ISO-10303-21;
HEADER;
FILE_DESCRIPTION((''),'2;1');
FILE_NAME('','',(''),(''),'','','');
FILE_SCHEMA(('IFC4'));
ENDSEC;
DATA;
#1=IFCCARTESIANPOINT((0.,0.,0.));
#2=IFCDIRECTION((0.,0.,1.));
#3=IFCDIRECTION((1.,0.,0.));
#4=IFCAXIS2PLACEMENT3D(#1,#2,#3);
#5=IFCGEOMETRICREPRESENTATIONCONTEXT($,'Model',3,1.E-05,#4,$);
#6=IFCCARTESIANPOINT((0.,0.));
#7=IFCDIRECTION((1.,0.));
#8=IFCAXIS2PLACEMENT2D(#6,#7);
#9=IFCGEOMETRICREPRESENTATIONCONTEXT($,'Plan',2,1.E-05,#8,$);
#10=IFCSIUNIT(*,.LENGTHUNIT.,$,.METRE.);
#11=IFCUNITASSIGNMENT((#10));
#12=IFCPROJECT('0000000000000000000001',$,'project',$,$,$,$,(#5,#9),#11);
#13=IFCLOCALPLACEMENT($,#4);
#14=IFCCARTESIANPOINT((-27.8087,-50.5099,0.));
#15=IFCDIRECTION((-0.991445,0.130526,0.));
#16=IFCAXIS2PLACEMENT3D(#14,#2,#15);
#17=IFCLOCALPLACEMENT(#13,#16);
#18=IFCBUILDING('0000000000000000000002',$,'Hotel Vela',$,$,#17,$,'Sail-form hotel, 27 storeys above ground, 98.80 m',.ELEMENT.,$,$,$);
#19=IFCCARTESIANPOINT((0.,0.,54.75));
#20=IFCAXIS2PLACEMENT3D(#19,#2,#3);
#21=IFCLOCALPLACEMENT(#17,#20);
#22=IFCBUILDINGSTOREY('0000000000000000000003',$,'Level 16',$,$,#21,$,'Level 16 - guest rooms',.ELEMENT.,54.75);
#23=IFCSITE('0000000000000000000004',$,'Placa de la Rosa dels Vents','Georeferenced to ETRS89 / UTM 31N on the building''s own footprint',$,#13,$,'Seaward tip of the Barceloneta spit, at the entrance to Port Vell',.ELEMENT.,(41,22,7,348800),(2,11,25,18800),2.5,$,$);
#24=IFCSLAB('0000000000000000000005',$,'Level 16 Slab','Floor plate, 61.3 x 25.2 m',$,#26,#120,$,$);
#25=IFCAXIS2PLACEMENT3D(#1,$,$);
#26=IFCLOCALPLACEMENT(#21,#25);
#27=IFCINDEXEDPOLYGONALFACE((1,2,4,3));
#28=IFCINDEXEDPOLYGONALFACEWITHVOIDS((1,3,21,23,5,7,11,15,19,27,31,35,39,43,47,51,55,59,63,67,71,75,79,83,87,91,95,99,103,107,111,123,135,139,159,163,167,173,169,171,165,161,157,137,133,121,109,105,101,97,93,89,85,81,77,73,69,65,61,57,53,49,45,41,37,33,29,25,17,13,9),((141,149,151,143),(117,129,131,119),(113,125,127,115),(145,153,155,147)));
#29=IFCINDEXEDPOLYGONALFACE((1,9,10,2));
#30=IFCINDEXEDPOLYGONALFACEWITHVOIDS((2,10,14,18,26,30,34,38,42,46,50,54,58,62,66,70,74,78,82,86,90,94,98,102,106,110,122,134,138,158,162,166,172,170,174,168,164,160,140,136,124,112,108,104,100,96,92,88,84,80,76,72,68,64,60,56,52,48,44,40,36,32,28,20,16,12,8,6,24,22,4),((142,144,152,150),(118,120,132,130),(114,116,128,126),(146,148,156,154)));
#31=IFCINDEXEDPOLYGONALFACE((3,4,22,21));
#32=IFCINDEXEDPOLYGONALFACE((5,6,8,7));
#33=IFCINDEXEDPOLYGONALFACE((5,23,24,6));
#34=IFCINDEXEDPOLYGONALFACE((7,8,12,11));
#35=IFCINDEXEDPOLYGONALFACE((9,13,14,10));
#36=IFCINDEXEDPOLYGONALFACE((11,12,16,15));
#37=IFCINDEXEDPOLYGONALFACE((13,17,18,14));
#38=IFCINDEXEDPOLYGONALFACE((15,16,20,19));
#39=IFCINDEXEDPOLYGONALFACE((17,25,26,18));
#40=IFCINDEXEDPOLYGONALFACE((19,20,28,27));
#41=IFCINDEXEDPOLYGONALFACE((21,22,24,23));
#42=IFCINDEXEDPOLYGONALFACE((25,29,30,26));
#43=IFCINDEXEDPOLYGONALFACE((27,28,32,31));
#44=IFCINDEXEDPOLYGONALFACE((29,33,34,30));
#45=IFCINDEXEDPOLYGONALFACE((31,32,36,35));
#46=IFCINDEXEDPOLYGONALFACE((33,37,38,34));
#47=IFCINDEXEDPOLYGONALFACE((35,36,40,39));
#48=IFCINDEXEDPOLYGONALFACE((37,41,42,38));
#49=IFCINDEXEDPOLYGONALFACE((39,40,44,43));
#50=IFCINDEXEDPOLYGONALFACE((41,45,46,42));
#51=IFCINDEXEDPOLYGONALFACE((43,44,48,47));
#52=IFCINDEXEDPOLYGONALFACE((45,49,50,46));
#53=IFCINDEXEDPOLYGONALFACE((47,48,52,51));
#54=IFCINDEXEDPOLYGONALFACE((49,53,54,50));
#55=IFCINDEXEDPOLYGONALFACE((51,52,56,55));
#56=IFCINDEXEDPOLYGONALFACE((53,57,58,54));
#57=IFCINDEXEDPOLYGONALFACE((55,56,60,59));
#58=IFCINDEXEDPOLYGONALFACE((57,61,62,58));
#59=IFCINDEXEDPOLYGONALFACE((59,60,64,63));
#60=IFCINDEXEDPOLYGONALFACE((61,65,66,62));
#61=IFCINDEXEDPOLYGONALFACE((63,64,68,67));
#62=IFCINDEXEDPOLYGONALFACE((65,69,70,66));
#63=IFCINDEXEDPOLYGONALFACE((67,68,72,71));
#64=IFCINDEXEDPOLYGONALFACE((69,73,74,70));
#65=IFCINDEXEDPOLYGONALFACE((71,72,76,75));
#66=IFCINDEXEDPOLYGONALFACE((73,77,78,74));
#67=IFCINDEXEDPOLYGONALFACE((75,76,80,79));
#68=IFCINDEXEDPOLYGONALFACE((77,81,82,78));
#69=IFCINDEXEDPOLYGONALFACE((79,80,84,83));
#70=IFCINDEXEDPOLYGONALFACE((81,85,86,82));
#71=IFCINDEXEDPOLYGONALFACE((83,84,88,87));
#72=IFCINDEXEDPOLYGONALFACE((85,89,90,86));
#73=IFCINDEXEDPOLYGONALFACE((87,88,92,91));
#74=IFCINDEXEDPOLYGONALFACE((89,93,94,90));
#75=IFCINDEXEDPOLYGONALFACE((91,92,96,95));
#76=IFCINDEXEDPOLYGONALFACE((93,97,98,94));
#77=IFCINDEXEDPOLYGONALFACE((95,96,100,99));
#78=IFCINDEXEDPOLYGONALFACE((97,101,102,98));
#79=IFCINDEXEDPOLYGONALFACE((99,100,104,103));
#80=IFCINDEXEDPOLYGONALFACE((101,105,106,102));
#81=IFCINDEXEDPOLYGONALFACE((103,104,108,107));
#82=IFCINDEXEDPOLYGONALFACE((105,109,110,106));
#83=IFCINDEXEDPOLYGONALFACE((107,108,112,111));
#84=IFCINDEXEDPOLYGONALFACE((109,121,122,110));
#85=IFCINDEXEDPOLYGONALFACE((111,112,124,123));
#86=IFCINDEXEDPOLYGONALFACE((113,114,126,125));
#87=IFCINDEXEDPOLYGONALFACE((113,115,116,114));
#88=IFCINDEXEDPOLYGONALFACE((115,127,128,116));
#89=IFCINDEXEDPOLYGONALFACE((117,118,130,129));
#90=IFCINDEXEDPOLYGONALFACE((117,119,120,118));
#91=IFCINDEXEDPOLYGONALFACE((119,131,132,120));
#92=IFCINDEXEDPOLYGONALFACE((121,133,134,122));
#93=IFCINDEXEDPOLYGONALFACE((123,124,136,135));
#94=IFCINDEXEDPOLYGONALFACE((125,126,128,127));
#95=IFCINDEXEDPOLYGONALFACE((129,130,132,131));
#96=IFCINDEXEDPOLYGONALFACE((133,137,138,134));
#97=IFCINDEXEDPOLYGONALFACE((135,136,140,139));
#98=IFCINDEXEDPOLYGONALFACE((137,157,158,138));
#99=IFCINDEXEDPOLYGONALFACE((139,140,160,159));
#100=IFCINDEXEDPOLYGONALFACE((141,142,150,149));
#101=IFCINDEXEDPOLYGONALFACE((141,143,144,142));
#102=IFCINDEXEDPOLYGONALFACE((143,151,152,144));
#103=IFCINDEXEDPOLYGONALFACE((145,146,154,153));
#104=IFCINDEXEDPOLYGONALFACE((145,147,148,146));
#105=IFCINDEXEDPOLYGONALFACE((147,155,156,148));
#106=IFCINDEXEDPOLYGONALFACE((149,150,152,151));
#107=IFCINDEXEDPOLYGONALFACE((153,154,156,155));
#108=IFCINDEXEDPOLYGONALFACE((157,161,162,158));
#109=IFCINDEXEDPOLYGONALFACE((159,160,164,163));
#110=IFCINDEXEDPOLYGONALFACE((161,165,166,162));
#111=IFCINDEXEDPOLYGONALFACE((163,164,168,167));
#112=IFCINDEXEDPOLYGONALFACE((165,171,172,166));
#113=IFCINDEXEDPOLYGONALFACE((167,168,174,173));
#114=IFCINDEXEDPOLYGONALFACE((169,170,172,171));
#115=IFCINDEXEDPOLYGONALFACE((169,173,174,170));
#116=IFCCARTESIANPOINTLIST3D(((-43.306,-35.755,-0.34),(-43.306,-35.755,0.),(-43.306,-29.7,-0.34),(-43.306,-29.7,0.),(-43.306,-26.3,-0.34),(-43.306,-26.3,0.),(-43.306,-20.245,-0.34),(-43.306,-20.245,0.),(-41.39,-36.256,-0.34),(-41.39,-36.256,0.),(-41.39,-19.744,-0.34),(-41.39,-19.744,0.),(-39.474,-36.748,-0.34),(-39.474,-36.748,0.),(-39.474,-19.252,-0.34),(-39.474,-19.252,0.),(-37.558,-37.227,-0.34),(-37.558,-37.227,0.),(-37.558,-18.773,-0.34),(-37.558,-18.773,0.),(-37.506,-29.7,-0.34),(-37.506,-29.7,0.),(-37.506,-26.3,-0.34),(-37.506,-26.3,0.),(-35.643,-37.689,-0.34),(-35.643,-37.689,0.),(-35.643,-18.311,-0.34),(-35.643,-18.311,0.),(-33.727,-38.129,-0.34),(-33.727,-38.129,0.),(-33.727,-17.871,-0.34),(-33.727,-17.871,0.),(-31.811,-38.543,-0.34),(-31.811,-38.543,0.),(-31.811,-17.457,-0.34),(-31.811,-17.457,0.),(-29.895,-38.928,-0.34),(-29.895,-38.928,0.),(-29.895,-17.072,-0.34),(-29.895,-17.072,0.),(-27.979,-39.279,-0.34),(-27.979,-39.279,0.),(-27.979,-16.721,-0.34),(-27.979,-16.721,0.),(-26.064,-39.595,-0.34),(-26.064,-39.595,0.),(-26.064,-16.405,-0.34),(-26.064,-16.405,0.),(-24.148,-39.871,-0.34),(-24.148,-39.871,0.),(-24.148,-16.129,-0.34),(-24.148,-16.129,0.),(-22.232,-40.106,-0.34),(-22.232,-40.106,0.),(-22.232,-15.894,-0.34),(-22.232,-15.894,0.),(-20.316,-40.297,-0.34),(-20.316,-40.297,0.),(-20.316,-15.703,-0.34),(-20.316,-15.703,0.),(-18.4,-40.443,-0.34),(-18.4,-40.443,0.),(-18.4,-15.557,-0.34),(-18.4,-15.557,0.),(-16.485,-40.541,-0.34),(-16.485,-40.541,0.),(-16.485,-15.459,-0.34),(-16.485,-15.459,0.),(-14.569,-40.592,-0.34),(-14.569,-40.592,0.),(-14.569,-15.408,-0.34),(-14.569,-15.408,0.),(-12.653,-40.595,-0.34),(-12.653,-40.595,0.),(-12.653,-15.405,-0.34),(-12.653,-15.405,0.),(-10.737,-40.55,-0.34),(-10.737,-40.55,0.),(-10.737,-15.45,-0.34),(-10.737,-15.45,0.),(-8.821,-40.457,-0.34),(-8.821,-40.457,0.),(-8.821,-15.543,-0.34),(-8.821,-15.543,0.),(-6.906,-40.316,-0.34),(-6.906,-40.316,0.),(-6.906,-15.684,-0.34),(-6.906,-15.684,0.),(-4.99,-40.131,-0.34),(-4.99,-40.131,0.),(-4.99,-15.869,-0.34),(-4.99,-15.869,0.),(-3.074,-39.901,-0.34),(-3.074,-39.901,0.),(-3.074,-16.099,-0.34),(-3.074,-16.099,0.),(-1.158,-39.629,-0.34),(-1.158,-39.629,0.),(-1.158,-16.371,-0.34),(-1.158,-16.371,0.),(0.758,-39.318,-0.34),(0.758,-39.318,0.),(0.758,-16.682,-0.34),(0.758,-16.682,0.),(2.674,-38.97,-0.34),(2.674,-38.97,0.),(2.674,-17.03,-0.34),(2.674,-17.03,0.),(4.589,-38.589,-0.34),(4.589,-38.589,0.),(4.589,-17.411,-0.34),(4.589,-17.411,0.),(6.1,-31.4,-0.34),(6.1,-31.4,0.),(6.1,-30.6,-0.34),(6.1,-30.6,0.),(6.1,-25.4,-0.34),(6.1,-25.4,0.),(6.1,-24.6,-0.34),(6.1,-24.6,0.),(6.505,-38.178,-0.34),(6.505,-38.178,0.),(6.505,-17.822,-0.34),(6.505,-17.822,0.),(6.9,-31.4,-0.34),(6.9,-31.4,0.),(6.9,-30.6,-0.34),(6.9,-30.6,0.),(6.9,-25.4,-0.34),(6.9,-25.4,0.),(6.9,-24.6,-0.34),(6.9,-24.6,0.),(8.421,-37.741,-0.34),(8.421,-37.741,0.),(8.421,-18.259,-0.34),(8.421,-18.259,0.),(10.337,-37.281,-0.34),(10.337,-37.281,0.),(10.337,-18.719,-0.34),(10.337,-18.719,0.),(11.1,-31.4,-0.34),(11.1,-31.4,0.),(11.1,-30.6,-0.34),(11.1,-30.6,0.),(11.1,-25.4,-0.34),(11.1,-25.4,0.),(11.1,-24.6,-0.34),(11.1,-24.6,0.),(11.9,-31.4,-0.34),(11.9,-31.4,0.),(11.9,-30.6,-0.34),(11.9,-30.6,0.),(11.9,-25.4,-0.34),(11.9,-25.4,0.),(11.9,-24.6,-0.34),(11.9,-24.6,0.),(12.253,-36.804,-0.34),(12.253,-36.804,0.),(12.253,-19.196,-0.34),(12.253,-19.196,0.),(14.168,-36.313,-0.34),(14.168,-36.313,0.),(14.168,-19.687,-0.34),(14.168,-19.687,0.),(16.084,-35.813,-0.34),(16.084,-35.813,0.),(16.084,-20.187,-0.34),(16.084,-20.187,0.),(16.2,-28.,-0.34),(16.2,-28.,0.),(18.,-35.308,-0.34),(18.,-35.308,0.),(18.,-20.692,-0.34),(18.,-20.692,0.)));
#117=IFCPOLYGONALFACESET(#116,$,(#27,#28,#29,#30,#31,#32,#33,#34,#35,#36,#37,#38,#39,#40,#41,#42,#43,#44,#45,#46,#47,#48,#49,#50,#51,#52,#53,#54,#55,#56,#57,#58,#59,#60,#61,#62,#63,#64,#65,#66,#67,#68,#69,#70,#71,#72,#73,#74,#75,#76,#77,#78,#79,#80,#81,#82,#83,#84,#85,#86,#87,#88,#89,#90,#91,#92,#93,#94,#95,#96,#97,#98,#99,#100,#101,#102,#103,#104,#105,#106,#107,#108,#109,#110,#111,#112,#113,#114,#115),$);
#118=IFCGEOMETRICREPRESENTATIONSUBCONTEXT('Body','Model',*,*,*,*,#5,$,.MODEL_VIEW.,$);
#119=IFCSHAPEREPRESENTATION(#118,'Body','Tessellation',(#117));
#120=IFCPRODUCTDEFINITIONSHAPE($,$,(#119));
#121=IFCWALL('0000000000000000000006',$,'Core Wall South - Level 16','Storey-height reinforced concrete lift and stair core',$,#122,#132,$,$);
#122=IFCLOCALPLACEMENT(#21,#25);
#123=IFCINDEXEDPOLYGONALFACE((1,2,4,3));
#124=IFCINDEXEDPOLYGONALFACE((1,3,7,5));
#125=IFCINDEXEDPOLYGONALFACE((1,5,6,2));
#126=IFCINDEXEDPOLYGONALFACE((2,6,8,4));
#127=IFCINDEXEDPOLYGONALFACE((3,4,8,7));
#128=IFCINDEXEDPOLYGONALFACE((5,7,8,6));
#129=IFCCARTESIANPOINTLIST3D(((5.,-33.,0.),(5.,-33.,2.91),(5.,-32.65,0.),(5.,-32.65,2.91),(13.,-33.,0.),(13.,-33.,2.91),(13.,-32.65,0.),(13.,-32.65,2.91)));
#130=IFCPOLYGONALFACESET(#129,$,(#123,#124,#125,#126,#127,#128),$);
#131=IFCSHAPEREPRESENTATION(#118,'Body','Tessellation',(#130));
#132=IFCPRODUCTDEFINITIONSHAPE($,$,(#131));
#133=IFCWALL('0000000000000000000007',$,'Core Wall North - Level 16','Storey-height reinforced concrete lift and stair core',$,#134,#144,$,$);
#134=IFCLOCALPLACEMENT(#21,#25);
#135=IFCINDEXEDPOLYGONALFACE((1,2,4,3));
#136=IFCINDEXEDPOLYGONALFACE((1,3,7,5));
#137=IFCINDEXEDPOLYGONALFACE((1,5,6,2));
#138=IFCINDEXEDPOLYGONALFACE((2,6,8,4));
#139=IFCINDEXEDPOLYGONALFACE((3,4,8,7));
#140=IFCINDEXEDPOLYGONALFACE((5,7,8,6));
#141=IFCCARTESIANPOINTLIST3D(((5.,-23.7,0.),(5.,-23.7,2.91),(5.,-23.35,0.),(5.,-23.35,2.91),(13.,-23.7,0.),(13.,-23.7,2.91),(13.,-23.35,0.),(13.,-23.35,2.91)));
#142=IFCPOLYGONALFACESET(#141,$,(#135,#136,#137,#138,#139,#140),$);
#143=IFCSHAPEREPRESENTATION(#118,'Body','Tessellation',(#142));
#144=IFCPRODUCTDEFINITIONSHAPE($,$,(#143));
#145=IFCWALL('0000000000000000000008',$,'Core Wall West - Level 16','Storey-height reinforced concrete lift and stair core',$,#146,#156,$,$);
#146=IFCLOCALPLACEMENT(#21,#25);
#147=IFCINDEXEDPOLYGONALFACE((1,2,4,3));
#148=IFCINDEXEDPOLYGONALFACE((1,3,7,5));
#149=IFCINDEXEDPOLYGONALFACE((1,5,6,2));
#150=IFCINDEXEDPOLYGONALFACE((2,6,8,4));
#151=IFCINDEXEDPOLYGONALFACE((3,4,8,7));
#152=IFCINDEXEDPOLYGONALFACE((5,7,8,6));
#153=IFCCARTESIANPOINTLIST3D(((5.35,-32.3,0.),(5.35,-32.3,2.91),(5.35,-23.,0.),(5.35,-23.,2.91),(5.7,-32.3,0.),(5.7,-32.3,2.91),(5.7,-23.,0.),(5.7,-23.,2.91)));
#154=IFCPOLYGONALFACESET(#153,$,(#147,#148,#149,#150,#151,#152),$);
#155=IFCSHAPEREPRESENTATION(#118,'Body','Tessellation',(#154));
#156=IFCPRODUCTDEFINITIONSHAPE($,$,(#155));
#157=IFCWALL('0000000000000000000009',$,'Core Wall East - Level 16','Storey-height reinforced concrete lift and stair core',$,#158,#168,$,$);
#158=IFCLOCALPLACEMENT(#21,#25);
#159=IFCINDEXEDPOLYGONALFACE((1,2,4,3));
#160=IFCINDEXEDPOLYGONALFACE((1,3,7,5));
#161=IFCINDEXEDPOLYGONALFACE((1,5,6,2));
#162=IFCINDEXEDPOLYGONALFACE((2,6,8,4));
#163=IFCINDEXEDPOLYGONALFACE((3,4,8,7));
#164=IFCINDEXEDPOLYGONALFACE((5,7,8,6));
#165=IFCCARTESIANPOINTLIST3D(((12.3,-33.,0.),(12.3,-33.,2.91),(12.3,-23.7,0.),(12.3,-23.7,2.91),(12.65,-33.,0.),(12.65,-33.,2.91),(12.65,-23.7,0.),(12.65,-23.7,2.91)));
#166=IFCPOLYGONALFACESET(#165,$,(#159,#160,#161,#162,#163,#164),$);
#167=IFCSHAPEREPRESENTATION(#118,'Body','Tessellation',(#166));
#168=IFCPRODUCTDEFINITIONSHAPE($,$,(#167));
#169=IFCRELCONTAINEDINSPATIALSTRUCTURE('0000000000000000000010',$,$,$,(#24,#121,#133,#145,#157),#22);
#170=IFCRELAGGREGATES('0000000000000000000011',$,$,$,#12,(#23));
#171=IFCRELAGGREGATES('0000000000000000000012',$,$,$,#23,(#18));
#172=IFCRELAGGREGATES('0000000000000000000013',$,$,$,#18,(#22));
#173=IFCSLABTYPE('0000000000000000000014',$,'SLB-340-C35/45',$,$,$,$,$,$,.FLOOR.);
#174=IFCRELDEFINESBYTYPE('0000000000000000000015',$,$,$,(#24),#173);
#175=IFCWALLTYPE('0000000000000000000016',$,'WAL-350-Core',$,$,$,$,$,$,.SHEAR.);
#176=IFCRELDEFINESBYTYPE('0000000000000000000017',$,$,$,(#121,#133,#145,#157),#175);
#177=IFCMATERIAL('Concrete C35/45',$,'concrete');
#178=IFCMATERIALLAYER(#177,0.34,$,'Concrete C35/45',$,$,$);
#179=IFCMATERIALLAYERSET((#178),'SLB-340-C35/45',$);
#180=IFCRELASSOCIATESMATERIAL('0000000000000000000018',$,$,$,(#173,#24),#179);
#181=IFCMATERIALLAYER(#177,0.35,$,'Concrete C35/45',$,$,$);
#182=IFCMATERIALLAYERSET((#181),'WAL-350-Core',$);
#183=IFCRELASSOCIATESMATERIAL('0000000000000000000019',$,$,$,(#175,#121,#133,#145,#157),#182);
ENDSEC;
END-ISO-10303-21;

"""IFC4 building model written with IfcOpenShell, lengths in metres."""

from ifc_helpers import new_model, si_unit, frame, origin_with_axes, origin_2d_with_axis, place, context, subcontext, project, spatial, line, indexed_curve, outline, extrude, material, layer, layer_set, layer_usage, type_object, element, save


model = new_model("IFC4")

# Units and contexts
model_context = context("Model", 3, precision=1e-05, world=origin_with_axes())
plan_context = context("Plan", 2, precision=1e-05, world=origin_2d_with_axis())
body_context = subcontext(model_context, "Body", "Model", "MODEL_VIEW")
ifc_project = project(units=[si_unit("LENGTHUNIT", "METRE")], contexts=[model_context, plan_context])

# Site, building, storey
site_placement = place(None, origin_with_axes())
site = spatial("IfcSite", under=ifc_project, at=site_placement, Name="Placa de la Rosa dels Vents", Description="Georeferenced to ETRS89 / UTM 31N on the building's own footprint", LongName="Seaward tip of the Barceloneta spit, at the entrance to Port Vell", CompositionType="ELEMENT", RefLatitude=(41, 22, 7, 348800), RefLongitude=(2, 11, 25, 18800), RefElevation=2.5)
building_placement = place(site_placement, frame((-27.8087, -50.5099, 0.0), z_axis=(0.0, 0.0, 1.0), x_axis=(-0.991445, 0.130526, 0.0)))
building = spatial("IfcBuilding", under=site, at=building_placement, Name="Hotel Vela", LongName="Sail-form hotel, 27 storeys above ground, 98.80 m", CompositionType="ELEMENT")
storey_placement = place(building_placement, frame((0.0, 0.0, 54.75), z_axis=(0.0, 0.0, 1.0), x_axis=(1.0, 0.0, 0.0)))
storey = spatial("IfcBuildingStorey", under=building, at=storey_placement, Name="Level 16", LongName="Level 16 - guest rooms", CompositionType="ELEMENT", Elevation=54.75)

# Shared definitions
ifc_material = material(Name="Concrete C35/45", Category="concrete")

# Slab, openings
ifc_layer_1 = layer(ifc_material, 0.34, Name="Concrete C35/45")
ifc_layer_set_1 = layer_set([ifc_layer_1], Name="SLB-340-C35/45")
ifc_layer_usage_1 = layer_usage(ifc_layer_set_1, "AXIS3", "POSITIVE", 0.0)
slab_type = type_object("IfcSlabType", Name="SLB-340-C35/45", PredefinedType="FLOOR", material=ifc_layer_set_1)
slab_placement = place(storey_placement, frame((0.0, 0.0, -0.34), z_axis=(0.0, 0.0, 1.0), x_axis=(1.0, 0.0, 0.0)))
slab = element("IfcSlab", 1, at=slab_placement, inside=storey, type_object=slab_type, material=ifc_layer_usage_1, Name="Level 16 Slab", Description="Floor plate, 61.3 x 25.2 m", context=body_context, shape_type="SweptSolid", body=[
    extrude(outline(indexed_curve([(-43.306, -35.755), (-41.39, -36.256), (-39.474, -36.748), (-37.558, -37.227), (-35.643, -37.689), (-33.727, -38.129), (-31.811, -38.543), (-29.895, -38.928), (-27.979, -39.279), (-26.064, -39.595), (-24.148, -39.871), (-22.232, -40.106), (-20.316, -40.297), (-18.4, -40.443), (-16.485, -40.541), (-14.569, -40.592), (-12.653, -40.595), (-10.737, -40.55), (-8.821, -40.457), (-6.906, -40.316), (-4.99, -40.131), (-3.074, -39.901), (-1.158, -39.629), (0.758, -39.318), (2.674, -38.97), (4.589, -38.589), (6.505, -38.178), (8.421, -37.741), (10.337, -37.281), (12.253, -36.804), (14.168, -36.313), (16.084, -35.813), (18.0, -35.308), (16.2, -28.0), (18.0, -20.692), (16.084, -20.187), (14.168, -19.687), (12.253, -19.196), (10.337, -18.719), (8.421, -18.259), (6.505, -17.822), (4.589, -17.411), (2.674, -17.03), (0.758, -16.682), (-1.158, -16.371), (-3.074, -16.099), (-4.99, -15.869), (-6.906, -15.684), (-8.821, -15.543), (-10.737, -15.45), (-12.653, -15.405), (-14.569, -15.408), (-16.485, -15.459), (-18.4, -15.557), (-20.316, -15.703), (-22.232, -15.894), (-24.148, -16.129), (-26.064, -16.405), (-27.979, -16.721), (-29.895, -17.072), (-31.811, -17.457), (-33.727, -17.871), (-35.643, -18.311), (-37.558, -18.773), (-39.474, -19.252), (-41.39, -19.744), (-43.306, -20.245), (-43.306, -26.3), (-37.506, -26.3), (-37.506, -29.7), (-43.306, -29.7)], segments=[line(1, 2, 3, 4, 5, 6, 7, 8, 9, 10, 11, 12, 13, 14, 15, 16, 17, 18, 19, 20, 21, 22, 23, 24, 25, 26, 27, 28, 29, 30, 31, 32, 33, 34, 35, 36, 37, 38, 39, 40, 41, 42, 43, 44, 45, 46, 47, 48, 49, 50, 51, 52, 53, 54, 55, 56, 57, 58, 59, 60, 61, 62, 63, 64, 65, 66, 67, 68, 69, 70, 71, 1)])), origin_with_axes(), (0.0, 0.0, 1.0), 0.34),
])
opening_1_placement = place(slab_placement, frame((6.1, -31.4, -0.05), z_axis=(0.0, 0.0, 1.0), x_axis=(1.0, 0.0, 0.0)))
element("IfcOpeningElement", 2, at=opening_1_placement, cuts=slab, PredefinedType="OPENING", context=body_context, shape_type="SweptSolid", body=[
    extrude(outline(indexed_curve([(0.0, 0.0), (0.8, 0.0), (0.8, 0.8), (0.0, 0.8)], segments=[line(1, 2, 3, 4, 1)])), origin_with_axes(), (0.0, 0.0, 1.0), 0.44),
])
opening_2_placement = place(slab_placement, frame((6.1, -25.4, -0.05), z_axis=(0.0, 0.0, 1.0), x_axis=(1.0, 0.0, 0.0)))
element("IfcOpeningElement", 3, at=opening_2_placement, cuts=slab, PredefinedType="OPENING", context=body_context, shape_type="SweptSolid", body=[
    extrude(outline(indexed_curve([(0.0, 0.0), (0.8, 0.0), (0.8, 0.8), (0.0, 0.8)], segments=[line(1, 2, 3, 4, 1)])), origin_with_axes(), (0.0, 0.0, 1.0), 0.44),
])
opening_3_placement = place(slab_placement, frame((11.1, -31.4, -0.05), z_axis=(0.0, 0.0, 1.0), x_axis=(1.0, 0.0, 0.0)))
element("IfcOpeningElement", 4, at=opening_3_placement, cuts=slab, PredefinedType="OPENING", context=body_context, shape_type="SweptSolid", body=[
    extrude(outline(indexed_curve([(0.0, 0.0), (0.8, 0.0), (0.8, 0.8), (0.0, 0.8)], segments=[line(1, 2, 3, 4, 1)])), origin_with_axes(), (0.0, 0.0, 1.0), 0.44),
])
opening_4_placement = place(slab_placement, frame((11.1, -25.4, -0.05), z_axis=(0.0, 0.0, 1.0), x_axis=(1.0, 0.0, 0.0)))
element("IfcOpeningElement", 5, at=opening_4_placement, cuts=slab, PredefinedType="OPENING", context=body_context, shape_type="SweptSolid", body=[
    extrude(outline(indexed_curve([(0.0, 0.0), (0.8, 0.0), (0.8, 0.8), (0.0, 0.8)], segments=[line(1, 2, 3, 4, 1)])), origin_with_axes(), (0.0, 0.0, 1.0), 0.44),
])

# Walls
ifc_layer_2 = layer(ifc_material, 0.35, Name="Concrete C35/45")
ifc_layer_set_2 = layer_set([ifc_layer_2], Name="WAL-350-Core")
ifc_layer_usage_2 = layer_usage(ifc_layer_set_2, "AXIS2", "POSITIVE", 0.0)
wall_type = type_object("IfcWallType", Name="WAL-350-Core", PredefinedType="SHEAR", material=ifc_layer_set_2)
wall_1_placement = place(storey_placement, frame((5.0, -33.0, 0.0), z_axis=(0.0, 0.0, 1.0), x_axis=(1.0, 0.0, 0.0)))
element("IfcWall", 6, at=wall_1_placement, inside=storey, type_object=wall_type, material=ifc_layer_usage_2, Name="Core Wall South - Level 16", Description="Storey-height reinforced concrete lift and stair core", context=body_context, shape_type="SweptSolid", body=[
    extrude(outline(indexed_curve([(0.0, 0.0), (8.0, 0.0), (8.0, 0.35), (0.0, 0.35)], segments=[line(1, 2, 3, 4, 1)])), origin_with_axes(), (0.0, 0.0, 1.0), 2.91),
])
ifc_layer_usage_3 = layer_usage(ifc_layer_set_2, "AXIS2", "POSITIVE", 0.0)
wall_2_placement = place(storey_placement, frame((13.0, -23.35, 0.0), z_axis=(0.0, 0.0, 1.0), x_axis=(-1.0, 0.0, 0.0)))
element("IfcWall", 7, at=wall_2_placement, inside=storey, type_object=wall_type, material=ifc_layer_usage_3, Name="Core Wall North - Level 16", Description="Storey-height reinforced concrete lift and stair core", context=body_context, shape_type="SweptSolid", body=[
    extrude(outline(indexed_curve([(0.0, 0.0), (8.0, 0.0), (8.0, 0.35), (0.0, 0.35)], segments=[line(1, 2, 3, 4, 1)])), origin_with_axes(), (0.0, 0.0, 1.0), 2.91),
])
ifc_layer_usage_4 = layer_usage(ifc_layer_set_2, "AXIS2", "POSITIVE", 0.0)
wall_3_placement = place(storey_placement, frame((5.35, -23.0, 0.0), z_axis=(0.0, 0.0, 1.0), x_axis=(0.0, -1.0, 0.0)))
element("IfcWall", 8, at=wall_3_placement, inside=storey, type_object=wall_type, material=ifc_layer_usage_4, Name="Core Wall West - Level 16", Description="Storey-height reinforced concrete lift and stair core", context=body_context, shape_type="SweptSolid", body=[
    extrude(outline(indexed_curve([(0.0, 0.0), (9.3, 0.0), (9.3, 0.35), (0.0, 0.35)], segments=[line(1, 2, 3, 4, 1)])), origin_with_axes(), (0.0, 0.0, 1.0), 2.91),
])
ifc_layer_usage_5 = layer_usage(ifc_layer_set_2, "AXIS2", "POSITIVE", 0.0)
wall_4_placement = place(storey_placement, frame((12.65, -33.0, 0.0), z_axis=(0.0, 0.0, 1.0), x_axis=(0.0, 1.0, 0.0)))
element("IfcWall", 9, at=wall_4_placement, inside=storey, type_object=wall_type, material=ifc_layer_usage_5, Name="Core Wall East - Level 16", Description="Storey-height reinforced concrete lift and stair core", context=body_context, shape_type="SweptSolid", body=[
    extrude(outline(indexed_curve([(0.0, 0.0), (9.3, 0.0), (9.3, 0.35), (0.0, 0.35)], segments=[line(1, 2, 3, 4, 1)])), origin_with_axes(), (0.0, 0.0, 1.0), 2.91),
])

save(model, "model.ifc")
